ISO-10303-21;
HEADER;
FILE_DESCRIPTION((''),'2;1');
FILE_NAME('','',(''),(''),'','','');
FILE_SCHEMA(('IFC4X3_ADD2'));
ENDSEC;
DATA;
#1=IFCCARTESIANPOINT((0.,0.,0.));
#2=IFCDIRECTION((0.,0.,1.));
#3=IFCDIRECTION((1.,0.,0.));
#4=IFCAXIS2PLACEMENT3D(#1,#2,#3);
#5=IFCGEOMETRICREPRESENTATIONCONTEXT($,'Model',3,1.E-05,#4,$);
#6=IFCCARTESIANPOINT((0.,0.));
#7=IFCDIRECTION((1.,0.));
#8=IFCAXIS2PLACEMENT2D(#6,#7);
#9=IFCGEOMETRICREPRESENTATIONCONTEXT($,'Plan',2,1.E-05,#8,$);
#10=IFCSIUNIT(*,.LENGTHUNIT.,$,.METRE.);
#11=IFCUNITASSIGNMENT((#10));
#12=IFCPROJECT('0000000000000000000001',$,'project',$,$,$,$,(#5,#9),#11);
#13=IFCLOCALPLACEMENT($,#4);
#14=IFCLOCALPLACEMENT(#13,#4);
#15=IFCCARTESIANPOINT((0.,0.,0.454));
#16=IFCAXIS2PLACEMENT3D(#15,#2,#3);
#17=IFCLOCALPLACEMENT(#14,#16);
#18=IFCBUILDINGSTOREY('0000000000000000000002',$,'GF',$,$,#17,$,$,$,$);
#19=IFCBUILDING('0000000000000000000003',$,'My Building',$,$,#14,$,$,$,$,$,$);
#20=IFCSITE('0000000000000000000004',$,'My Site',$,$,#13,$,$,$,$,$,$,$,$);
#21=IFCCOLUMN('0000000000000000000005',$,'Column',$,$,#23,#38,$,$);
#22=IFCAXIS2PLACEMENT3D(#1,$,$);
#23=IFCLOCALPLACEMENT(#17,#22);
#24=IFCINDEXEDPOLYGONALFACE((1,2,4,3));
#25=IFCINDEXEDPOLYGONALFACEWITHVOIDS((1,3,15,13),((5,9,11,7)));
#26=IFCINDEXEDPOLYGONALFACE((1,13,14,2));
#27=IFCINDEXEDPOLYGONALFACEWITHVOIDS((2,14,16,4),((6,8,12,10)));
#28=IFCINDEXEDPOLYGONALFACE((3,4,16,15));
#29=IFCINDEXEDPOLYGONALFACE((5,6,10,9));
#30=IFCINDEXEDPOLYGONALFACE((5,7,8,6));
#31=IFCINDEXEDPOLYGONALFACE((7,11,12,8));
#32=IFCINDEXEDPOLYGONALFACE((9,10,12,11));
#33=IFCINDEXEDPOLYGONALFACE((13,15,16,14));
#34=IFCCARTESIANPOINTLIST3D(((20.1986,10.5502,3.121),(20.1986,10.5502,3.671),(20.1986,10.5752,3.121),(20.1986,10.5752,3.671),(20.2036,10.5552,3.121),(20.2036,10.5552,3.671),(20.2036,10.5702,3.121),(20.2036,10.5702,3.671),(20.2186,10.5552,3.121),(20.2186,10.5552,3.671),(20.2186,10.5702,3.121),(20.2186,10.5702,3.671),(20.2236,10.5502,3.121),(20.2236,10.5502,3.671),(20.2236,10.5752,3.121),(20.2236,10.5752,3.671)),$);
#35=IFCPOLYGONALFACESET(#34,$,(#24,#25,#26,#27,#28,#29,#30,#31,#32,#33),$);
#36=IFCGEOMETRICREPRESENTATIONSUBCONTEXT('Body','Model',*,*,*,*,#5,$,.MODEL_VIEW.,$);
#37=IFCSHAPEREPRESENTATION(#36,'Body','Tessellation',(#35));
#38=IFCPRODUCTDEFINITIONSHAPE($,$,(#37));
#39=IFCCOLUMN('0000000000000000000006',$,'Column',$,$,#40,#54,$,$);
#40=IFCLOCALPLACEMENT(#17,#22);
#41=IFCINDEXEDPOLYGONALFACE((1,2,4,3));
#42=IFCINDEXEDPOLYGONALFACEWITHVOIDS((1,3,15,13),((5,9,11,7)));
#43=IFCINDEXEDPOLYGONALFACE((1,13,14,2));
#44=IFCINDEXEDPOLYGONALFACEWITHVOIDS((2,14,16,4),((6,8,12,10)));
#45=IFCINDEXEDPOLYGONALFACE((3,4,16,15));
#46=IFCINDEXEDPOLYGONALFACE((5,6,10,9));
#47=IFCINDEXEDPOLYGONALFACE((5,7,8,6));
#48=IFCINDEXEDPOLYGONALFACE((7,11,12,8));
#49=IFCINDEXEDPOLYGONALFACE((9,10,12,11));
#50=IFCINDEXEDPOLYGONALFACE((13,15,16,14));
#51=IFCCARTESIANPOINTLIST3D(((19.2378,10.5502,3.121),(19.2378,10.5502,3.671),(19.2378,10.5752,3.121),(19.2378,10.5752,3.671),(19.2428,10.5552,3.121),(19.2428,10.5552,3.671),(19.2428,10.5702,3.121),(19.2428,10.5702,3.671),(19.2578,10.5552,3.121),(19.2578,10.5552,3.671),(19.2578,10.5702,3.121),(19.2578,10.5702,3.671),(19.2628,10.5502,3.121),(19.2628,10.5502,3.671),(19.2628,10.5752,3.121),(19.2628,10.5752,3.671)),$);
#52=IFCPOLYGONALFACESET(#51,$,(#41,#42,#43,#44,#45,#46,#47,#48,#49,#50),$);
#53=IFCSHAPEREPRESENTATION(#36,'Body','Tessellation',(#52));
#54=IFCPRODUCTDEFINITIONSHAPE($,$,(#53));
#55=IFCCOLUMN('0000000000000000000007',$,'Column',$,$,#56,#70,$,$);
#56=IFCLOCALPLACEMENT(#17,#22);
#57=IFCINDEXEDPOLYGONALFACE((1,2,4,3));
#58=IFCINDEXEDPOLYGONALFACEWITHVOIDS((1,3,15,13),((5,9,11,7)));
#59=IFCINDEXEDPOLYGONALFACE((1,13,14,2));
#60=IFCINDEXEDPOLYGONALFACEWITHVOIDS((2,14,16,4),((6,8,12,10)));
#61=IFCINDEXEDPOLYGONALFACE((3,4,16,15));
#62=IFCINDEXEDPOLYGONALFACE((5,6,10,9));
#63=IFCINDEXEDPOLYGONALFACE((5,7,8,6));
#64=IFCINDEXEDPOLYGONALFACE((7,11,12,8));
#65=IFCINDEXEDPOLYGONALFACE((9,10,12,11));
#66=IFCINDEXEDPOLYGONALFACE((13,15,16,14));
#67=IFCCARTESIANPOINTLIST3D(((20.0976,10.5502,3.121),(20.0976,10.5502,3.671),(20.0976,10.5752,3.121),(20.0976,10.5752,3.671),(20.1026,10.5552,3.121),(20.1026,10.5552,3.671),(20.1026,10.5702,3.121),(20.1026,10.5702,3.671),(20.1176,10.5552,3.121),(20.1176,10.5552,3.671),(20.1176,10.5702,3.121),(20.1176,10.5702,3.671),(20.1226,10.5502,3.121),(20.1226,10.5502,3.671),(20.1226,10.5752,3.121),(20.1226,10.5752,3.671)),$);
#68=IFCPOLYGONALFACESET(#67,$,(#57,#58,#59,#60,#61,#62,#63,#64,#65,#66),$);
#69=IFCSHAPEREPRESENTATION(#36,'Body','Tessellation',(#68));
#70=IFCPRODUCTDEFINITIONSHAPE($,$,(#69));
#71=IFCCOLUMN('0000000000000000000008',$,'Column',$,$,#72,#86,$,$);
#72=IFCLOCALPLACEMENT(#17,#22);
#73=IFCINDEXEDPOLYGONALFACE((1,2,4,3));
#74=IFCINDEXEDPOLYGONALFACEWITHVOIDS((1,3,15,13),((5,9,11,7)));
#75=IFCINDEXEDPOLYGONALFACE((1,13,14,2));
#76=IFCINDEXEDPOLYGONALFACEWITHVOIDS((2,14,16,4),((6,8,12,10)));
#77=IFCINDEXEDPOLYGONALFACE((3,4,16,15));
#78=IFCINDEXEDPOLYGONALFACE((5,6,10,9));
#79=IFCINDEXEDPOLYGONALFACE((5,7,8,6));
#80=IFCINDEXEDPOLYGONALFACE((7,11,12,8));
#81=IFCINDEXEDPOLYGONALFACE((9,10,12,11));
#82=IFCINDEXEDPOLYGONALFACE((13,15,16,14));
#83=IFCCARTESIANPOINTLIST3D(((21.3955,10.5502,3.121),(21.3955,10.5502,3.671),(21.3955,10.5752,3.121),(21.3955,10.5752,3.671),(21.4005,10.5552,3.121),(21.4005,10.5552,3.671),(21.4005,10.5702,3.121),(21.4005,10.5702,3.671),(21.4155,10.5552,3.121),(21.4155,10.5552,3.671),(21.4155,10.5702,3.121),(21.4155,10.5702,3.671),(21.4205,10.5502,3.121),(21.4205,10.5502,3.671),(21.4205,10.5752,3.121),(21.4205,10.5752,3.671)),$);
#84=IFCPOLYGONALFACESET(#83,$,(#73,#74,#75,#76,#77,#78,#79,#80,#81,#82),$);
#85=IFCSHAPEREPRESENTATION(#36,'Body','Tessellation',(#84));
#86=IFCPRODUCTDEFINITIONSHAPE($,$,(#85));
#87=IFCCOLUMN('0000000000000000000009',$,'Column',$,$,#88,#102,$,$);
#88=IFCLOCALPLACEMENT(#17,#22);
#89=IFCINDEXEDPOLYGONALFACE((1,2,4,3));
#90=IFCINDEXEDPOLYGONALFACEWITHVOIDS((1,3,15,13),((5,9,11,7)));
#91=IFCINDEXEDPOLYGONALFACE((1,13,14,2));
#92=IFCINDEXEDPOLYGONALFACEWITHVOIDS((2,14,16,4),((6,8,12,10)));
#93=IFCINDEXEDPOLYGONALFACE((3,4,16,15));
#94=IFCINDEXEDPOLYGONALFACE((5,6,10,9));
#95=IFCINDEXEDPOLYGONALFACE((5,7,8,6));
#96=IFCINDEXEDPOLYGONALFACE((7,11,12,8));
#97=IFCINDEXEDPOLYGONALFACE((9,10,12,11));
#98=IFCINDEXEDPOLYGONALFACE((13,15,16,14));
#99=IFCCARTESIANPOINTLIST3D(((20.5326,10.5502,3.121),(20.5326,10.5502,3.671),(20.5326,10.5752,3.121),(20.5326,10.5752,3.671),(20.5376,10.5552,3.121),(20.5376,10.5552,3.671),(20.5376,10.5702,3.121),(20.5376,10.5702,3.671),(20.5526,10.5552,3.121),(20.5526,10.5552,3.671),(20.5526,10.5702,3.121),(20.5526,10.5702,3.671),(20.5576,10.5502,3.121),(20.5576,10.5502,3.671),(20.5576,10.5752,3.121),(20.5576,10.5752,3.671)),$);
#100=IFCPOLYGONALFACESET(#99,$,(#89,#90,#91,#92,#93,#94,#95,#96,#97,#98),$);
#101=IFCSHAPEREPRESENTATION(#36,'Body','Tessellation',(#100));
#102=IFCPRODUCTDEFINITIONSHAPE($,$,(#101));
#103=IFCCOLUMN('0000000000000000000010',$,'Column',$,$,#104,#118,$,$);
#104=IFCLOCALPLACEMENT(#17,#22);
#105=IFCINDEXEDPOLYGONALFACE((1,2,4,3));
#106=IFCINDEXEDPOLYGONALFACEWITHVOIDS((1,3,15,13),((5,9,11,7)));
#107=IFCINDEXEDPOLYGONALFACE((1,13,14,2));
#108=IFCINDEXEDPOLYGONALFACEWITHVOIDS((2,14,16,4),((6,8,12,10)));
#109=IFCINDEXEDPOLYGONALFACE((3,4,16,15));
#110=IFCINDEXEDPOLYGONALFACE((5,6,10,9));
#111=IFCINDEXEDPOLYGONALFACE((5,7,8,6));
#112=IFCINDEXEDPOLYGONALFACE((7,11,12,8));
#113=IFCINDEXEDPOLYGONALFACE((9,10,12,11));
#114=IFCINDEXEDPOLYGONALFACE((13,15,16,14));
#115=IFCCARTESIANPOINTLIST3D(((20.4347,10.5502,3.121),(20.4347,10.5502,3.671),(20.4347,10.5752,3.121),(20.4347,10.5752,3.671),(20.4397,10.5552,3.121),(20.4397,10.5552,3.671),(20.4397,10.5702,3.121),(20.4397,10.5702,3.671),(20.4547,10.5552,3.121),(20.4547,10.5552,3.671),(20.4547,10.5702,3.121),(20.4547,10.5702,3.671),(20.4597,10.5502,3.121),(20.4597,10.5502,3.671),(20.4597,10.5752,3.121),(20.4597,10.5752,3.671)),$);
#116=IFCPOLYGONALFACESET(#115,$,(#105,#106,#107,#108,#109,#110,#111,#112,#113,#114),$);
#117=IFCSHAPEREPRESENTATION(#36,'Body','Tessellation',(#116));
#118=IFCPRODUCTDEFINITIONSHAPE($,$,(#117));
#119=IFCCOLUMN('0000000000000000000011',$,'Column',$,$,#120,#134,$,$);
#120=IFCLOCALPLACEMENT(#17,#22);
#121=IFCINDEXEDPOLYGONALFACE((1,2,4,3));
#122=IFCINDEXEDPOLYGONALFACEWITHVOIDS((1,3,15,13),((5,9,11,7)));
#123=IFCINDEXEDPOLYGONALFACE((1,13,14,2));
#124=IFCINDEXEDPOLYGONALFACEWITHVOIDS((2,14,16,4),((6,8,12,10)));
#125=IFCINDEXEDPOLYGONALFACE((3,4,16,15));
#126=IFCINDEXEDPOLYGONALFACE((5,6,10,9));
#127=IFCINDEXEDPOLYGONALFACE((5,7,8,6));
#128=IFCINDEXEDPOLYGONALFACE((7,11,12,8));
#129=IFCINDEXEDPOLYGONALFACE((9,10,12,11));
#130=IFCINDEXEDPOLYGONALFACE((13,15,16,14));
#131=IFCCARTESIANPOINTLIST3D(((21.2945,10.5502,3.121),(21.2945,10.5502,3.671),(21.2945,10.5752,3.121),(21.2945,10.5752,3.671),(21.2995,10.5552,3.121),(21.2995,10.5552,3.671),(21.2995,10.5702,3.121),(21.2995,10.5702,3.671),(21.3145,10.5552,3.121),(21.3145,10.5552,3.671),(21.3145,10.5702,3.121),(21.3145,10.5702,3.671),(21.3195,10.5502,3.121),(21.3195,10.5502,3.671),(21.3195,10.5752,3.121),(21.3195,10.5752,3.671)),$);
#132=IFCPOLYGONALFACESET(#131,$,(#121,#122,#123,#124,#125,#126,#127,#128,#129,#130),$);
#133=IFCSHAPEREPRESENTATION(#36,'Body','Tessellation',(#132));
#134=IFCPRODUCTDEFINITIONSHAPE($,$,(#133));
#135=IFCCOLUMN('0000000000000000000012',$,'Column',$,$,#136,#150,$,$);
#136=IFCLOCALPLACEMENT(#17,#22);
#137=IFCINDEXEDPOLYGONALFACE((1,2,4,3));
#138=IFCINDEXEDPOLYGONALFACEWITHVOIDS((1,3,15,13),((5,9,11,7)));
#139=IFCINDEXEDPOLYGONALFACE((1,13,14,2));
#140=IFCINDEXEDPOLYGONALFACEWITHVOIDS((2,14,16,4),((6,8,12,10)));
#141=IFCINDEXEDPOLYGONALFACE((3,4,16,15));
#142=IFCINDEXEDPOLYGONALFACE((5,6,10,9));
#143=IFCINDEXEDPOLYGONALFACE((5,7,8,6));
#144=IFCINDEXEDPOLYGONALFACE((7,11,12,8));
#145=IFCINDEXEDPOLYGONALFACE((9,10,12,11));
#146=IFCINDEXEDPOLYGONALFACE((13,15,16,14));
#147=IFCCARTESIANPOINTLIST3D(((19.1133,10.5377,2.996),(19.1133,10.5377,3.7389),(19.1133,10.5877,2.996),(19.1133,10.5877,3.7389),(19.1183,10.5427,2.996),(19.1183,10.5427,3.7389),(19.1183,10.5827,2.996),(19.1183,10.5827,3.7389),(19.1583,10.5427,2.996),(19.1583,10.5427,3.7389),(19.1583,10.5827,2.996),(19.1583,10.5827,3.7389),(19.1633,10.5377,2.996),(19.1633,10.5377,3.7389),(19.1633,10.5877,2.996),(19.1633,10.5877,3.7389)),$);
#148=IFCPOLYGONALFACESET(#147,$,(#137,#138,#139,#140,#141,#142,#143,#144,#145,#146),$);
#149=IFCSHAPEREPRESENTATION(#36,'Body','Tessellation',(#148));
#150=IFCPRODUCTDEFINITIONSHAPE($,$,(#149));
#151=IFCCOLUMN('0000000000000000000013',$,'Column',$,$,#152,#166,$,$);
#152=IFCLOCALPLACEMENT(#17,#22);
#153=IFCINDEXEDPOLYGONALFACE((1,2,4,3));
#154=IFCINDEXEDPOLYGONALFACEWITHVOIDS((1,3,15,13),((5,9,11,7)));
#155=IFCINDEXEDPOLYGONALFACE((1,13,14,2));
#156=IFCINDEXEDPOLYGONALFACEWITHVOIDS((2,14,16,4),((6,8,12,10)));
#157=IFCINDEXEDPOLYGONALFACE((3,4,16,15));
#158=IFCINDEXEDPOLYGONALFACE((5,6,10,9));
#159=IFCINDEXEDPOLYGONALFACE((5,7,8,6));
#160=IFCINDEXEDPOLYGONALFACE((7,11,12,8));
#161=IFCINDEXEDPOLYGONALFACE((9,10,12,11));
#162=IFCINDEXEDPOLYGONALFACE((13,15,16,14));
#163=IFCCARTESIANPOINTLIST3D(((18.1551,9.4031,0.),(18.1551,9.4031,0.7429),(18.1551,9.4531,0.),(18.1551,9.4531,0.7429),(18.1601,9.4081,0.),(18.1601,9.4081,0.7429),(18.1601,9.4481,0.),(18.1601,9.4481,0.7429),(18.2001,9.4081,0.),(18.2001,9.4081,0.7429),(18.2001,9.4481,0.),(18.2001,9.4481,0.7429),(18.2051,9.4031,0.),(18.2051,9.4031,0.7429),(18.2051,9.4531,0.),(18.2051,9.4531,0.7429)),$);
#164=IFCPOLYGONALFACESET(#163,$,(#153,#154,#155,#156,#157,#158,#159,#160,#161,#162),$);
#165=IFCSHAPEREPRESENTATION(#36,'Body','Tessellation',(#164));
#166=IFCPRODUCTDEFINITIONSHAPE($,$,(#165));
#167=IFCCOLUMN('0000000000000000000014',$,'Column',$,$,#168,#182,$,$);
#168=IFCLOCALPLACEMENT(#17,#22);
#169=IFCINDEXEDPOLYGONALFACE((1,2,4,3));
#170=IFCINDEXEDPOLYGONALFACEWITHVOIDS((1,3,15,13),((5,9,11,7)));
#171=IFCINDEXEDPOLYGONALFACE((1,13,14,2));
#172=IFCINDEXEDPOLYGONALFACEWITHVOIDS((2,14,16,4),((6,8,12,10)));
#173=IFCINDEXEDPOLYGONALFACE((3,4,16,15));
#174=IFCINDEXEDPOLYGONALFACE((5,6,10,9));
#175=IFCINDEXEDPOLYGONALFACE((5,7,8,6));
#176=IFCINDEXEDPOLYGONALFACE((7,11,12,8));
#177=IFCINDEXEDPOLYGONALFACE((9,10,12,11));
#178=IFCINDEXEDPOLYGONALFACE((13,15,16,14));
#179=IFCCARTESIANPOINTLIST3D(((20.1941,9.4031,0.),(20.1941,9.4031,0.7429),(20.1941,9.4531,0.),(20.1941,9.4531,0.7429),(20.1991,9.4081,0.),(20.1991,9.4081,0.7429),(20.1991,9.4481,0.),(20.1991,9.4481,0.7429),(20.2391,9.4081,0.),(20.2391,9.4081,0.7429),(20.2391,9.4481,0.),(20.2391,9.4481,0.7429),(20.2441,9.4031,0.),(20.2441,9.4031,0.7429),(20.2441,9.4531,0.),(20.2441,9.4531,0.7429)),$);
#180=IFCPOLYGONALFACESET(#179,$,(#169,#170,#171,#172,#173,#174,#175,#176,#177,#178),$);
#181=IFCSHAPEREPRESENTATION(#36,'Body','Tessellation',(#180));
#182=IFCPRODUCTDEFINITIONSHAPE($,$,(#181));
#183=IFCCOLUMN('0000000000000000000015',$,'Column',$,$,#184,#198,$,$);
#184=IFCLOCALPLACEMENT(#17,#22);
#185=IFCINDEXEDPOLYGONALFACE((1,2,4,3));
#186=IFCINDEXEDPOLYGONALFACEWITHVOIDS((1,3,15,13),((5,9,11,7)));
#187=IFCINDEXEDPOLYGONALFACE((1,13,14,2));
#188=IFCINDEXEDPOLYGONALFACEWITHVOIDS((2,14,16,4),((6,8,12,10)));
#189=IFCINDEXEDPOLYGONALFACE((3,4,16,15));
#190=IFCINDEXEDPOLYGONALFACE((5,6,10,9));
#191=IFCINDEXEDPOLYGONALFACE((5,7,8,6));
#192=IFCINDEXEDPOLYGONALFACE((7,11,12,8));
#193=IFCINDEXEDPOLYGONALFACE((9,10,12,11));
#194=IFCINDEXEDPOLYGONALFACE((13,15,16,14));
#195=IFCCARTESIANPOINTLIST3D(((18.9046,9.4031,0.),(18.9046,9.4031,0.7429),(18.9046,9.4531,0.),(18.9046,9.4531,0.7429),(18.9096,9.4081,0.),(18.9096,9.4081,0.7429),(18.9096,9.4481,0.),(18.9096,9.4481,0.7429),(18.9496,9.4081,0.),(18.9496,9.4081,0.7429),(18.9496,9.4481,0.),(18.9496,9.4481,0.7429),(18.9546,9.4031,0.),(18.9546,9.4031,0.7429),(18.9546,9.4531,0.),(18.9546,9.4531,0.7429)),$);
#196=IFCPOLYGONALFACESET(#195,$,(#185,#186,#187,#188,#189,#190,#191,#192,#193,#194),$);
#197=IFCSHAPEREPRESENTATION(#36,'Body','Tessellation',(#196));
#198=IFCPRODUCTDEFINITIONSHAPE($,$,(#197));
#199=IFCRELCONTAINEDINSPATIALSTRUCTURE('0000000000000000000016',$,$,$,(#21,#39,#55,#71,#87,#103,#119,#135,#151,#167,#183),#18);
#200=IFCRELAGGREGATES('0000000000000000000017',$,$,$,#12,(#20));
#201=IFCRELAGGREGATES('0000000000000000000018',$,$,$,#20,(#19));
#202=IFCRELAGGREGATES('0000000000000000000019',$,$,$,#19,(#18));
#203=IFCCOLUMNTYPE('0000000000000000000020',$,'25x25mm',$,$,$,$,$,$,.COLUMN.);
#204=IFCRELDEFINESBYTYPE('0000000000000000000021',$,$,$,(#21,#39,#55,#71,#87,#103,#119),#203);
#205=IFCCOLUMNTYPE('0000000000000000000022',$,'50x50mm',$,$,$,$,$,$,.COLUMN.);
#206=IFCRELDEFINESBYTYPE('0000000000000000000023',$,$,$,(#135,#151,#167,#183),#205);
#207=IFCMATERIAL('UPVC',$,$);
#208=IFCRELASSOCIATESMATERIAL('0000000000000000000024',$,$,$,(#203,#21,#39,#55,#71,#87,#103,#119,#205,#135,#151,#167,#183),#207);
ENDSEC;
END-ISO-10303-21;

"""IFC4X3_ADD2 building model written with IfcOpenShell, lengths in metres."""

from ifc_helpers import new_model, si_unit, frame, origin_with_axes, origin_2d_with_axis, place, context, subcontext, project, spatial, hollow_rectangle, extrude, material, material_profile, profile_set, profile_usage, type_object, element, save


model = new_model("IFC4X3_ADD2")

# Units and contexts
model_context = context("Model", 3, precision=1e-05, world=origin_with_axes())
plan_context = context("Plan", 2, precision=1e-05, world=origin_2d_with_axis())
body_context = subcontext(model_context, "Body", "Model", "MODEL_VIEW")
ifc_project = project(units=[si_unit("LENGTHUNIT", "METRE")], contexts=[model_context, plan_context])

# Site, building, storey
site_placement = place(None, origin_with_axes())
site = spatial("IfcSite", under=ifc_project, at=site_placement, Name="My Site")
building_placement = place(site_placement, origin_with_axes())
building = spatial("IfcBuilding", under=site, at=building_placement, Name="My Building")
storey_placement = place(building_placement, frame((0.0, 0.0, 0.454), z_axis=(0.0, 0.0, 1.0), x_axis=(1.0, 0.0, 0.0)))
storey = spatial("IfcBuildingStorey", under=building, at=storey_placement, Name="GF")

# Columns
ifc_material = material(Name="UPVC")
ifc_material_profile_1 = material_profile(ifc_material, hollow_rectangle(XDim=0.025, YDim=0.025, WallThickness=0.005))
ifc_profile_set_1 = profile_set([ifc_material_profile_1])
column_type_1 = type_object("IfcColumnType", Name="25x25mm", PredefinedType="COLUMN", material=ifc_profile_set_1)
ifc_profile_usage_1 = profile_usage(ifc_profile_set_1)
column_1_placement = place(storey_placement, frame((20.2111, 10.5627, 3.121), z_axis=(0.0, 0.0, 1.0), x_axis=(0.0, -1.0, 0.0)))
element("IfcColumn", 1, at=column_1_placement, inside=storey, type_object=column_type_1, material=ifc_profile_usage_1, Name="Column", context=body_context, shape_type="SweptSolid", body=[
    extrude(hollow_rectangle(XDim=0.025, YDim=0.025, WallThickness=0.005), origin_with_axes(), (0.0, 0.0, 1.0), 0.55),
])
ifc_profile_usage_2 = profile_usage(ifc_profile_set_1)
column_2_placement = place(storey_placement, frame((19.2503, 10.5627, 3.121), z_axis=(0.0, 0.0, 1.0), x_axis=(0.0, -1.0, 0.0)))
element("IfcColumn", 2, at=column_2_placement, inside=storey, type_object=column_type_1, material=ifc_profile_usage_2, Name="Column", context=body_context, shape_type="SweptSolid", body=[
    extrude(hollow_rectangle(XDim=0.025, YDim=0.025, WallThickness=0.005), origin_with_axes(), (0.0, 0.0, 1.0), 0.55),
])
ifc_profile_usage_3 = profile_usage(ifc_profile_set_1)
column_3_placement = place(storey_placement, frame((20.1101, 10.5627, 3.121), z_axis=(0.0, 0.0, 1.0), x_axis=(0.0, -1.0, 0.0)))
element("IfcColumn", 3, at=column_3_placement, inside=storey, type_object=column_type_1, material=ifc_profile_usage_3, Name="Column", context=body_context, shape_type="SweptSolid", body=[
    extrude(hollow_rectangle(XDim=0.025, YDim=0.025, WallThickness=0.005), origin_with_axes(), (0.0, 0.0, 1.0), 0.55),
])
ifc_profile_usage_4 = profile_usage(ifc_profile_set_1)
column_4_placement = place(storey_placement, frame((21.408, 10.5627, 3.121), z_axis=(0.0, 0.0, 1.0), x_axis=(0.0, -1.0, 0.0)))
element("IfcColumn", 4, at=column_4_placement, inside=storey, type_object=column_type_1, material=ifc_profile_usage_4, Name="Column", context=body_context, shape_type="SweptSolid", body=[
    extrude(hollow_rectangle(XDim=0.025, YDim=0.025, WallThickness=0.005), origin_with_axes(), (0.0, 0.0, 1.0), 0.55),
])
ifc_profile_usage_5 = profile_usage(ifc_profile_set_1)
column_5_placement = place(storey_placement, frame((20.5451, 10.5627, 3.121), z_axis=(0.0, 0.0, 1.0), x_axis=(0.0, -1.0, 0.0)))
element("IfcColumn", 5, at=column_5_placement, inside=storey, type_object=column_type_1, material=ifc_profile_usage_5, Name="Column", context=body_context, shape_type="SweptSolid", body=[
    extrude(hollow_rectangle(XDim=0.025, YDim=0.025, WallThickness=0.005), origin_with_axes(), (0.0, 0.0, 1.0), 0.55),
])
ifc_profile_usage_6 = profile_usage(ifc_profile_set_1)
column_6_placement = place(storey_placement, frame((20.4472, 10.5627, 3.121), z_axis=(0.0, 0.0, 1.0), x_axis=(0.0, -1.0, 0.0)))
element("IfcColumn", 6, at=column_6_placement, inside=storey, type_object=column_type_1, material=ifc_profile_usage_6, Name="Column", context=body_context, shape_type="SweptSolid", body=[
    extrude(hollow_rectangle(XDim=0.025, YDim=0.025, WallThickness=0.005), origin_with_axes(), (0.0, 0.0, 1.0), 0.55),
])
ifc_profile_usage_7 = profile_usage(ifc_profile_set_1)
column_7_placement = place(storey_placement, frame((21.307, 10.5627, 3.121), z_axis=(0.0, 0.0, 1.0), x_axis=(0.0, -1.0, 0.0)))
element("IfcColumn", 7, at=column_7_placement, inside=storey, type_object=column_type_1, material=ifc_profile_usage_7, Name="Column", context=body_context, shape_type="SweptSolid", body=[
    extrude(hollow_rectangle(XDim=0.025, YDim=0.025, WallThickness=0.005), origin_with_axes(), (0.0, 0.0, 1.0), 0.55),
])
ifc_material_profile_2 = material_profile(ifc_material, hollow_rectangle(XDim=0.05, YDim=0.05, WallThickness=0.005))
ifc_profile_set_2 = profile_set([ifc_material_profile_2])
ifc_profile_usage_8 = profile_usage(ifc_profile_set_2)
column_type_2 = type_object("IfcColumnType", Name="50x50mm", PredefinedType="COLUMN", material=ifc_profile_set_2)
column_8_placement = place(storey_placement, frame((19.1383, 10.5627, 2.996), z_axis=(0.0, 0.0, 1.0), x_axis=(1.0, 0.0, 0.0)))
element("IfcColumn", 8, at=column_8_placement, inside=storey, type_object=column_type_2, material=ifc_profile_usage_8, Name="Column", context=body_context, shape_type="SweptSolid", body=[
    extrude(hollow_rectangle(XDim=0.05, YDim=0.05, WallThickness=0.005), origin_with_axes(), (0.0, 0.0, 1.0), 0.7429),
])
ifc_profile_usage_9 = profile_usage(ifc_profile_set_2)
column_9_placement = place(storey_placement, frame((18.1801, 9.4281, 0.0), z_axis=(0.0, 0.0, 1.0), x_axis=(1.0, 0.0, 0.0)))
element("IfcColumn", 9, at=column_9_placement, inside=storey, type_object=column_type_2, material=ifc_profile_usage_9, Name="Column", context=body_context, shape_type="SweptSolid", body=[
    extrude(hollow_rectangle(XDim=0.05, YDim=0.05, WallThickness=0.005), origin_with_axes(), (0.0, 0.0, 1.0), 0.7429),
])
ifc_profile_usage_10 = profile_usage(ifc_profile_set_2)
column_10_placement = place(storey_placement, frame((20.2191, 9.4281, 0.0), z_axis=(0.0, 0.0, 1.0), x_axis=(1.0, 0.0, 0.0)))
element("IfcColumn", 10, at=column_10_placement, inside=storey, type_object=column_type_2, material=ifc_profile_usage_10, Name="Column", context=body_context, shape_type="SweptSolid", body=[
    extrude(hollow_rectangle(XDim=0.05, YDim=0.05, WallThickness=0.005), origin_with_axes(), (0.0, 0.0, 1.0), 0.7429),
])
ifc_profile_usage_11 = profile_usage(ifc_profile_set_2)
column_11_placement = place(storey_placement, frame((18.9296, 9.4281, 0.0), z_axis=(0.0, 0.0, 1.0), x_axis=(1.0, 0.0, 0.0)))
element("IfcColumn", 11, at=column_11_placement, inside=storey, type_object=column_type_2, material=ifc_profile_usage_11, Name="Column", context=body_context, shape_type="SweptSolid", body=[
    extrude(hollow_rectangle(XDim=0.05, YDim=0.05, WallThickness=0.005), origin_with_axes(), (0.0, 0.0, 1.0), 0.7429),
])

save(model, "model.ifc")
